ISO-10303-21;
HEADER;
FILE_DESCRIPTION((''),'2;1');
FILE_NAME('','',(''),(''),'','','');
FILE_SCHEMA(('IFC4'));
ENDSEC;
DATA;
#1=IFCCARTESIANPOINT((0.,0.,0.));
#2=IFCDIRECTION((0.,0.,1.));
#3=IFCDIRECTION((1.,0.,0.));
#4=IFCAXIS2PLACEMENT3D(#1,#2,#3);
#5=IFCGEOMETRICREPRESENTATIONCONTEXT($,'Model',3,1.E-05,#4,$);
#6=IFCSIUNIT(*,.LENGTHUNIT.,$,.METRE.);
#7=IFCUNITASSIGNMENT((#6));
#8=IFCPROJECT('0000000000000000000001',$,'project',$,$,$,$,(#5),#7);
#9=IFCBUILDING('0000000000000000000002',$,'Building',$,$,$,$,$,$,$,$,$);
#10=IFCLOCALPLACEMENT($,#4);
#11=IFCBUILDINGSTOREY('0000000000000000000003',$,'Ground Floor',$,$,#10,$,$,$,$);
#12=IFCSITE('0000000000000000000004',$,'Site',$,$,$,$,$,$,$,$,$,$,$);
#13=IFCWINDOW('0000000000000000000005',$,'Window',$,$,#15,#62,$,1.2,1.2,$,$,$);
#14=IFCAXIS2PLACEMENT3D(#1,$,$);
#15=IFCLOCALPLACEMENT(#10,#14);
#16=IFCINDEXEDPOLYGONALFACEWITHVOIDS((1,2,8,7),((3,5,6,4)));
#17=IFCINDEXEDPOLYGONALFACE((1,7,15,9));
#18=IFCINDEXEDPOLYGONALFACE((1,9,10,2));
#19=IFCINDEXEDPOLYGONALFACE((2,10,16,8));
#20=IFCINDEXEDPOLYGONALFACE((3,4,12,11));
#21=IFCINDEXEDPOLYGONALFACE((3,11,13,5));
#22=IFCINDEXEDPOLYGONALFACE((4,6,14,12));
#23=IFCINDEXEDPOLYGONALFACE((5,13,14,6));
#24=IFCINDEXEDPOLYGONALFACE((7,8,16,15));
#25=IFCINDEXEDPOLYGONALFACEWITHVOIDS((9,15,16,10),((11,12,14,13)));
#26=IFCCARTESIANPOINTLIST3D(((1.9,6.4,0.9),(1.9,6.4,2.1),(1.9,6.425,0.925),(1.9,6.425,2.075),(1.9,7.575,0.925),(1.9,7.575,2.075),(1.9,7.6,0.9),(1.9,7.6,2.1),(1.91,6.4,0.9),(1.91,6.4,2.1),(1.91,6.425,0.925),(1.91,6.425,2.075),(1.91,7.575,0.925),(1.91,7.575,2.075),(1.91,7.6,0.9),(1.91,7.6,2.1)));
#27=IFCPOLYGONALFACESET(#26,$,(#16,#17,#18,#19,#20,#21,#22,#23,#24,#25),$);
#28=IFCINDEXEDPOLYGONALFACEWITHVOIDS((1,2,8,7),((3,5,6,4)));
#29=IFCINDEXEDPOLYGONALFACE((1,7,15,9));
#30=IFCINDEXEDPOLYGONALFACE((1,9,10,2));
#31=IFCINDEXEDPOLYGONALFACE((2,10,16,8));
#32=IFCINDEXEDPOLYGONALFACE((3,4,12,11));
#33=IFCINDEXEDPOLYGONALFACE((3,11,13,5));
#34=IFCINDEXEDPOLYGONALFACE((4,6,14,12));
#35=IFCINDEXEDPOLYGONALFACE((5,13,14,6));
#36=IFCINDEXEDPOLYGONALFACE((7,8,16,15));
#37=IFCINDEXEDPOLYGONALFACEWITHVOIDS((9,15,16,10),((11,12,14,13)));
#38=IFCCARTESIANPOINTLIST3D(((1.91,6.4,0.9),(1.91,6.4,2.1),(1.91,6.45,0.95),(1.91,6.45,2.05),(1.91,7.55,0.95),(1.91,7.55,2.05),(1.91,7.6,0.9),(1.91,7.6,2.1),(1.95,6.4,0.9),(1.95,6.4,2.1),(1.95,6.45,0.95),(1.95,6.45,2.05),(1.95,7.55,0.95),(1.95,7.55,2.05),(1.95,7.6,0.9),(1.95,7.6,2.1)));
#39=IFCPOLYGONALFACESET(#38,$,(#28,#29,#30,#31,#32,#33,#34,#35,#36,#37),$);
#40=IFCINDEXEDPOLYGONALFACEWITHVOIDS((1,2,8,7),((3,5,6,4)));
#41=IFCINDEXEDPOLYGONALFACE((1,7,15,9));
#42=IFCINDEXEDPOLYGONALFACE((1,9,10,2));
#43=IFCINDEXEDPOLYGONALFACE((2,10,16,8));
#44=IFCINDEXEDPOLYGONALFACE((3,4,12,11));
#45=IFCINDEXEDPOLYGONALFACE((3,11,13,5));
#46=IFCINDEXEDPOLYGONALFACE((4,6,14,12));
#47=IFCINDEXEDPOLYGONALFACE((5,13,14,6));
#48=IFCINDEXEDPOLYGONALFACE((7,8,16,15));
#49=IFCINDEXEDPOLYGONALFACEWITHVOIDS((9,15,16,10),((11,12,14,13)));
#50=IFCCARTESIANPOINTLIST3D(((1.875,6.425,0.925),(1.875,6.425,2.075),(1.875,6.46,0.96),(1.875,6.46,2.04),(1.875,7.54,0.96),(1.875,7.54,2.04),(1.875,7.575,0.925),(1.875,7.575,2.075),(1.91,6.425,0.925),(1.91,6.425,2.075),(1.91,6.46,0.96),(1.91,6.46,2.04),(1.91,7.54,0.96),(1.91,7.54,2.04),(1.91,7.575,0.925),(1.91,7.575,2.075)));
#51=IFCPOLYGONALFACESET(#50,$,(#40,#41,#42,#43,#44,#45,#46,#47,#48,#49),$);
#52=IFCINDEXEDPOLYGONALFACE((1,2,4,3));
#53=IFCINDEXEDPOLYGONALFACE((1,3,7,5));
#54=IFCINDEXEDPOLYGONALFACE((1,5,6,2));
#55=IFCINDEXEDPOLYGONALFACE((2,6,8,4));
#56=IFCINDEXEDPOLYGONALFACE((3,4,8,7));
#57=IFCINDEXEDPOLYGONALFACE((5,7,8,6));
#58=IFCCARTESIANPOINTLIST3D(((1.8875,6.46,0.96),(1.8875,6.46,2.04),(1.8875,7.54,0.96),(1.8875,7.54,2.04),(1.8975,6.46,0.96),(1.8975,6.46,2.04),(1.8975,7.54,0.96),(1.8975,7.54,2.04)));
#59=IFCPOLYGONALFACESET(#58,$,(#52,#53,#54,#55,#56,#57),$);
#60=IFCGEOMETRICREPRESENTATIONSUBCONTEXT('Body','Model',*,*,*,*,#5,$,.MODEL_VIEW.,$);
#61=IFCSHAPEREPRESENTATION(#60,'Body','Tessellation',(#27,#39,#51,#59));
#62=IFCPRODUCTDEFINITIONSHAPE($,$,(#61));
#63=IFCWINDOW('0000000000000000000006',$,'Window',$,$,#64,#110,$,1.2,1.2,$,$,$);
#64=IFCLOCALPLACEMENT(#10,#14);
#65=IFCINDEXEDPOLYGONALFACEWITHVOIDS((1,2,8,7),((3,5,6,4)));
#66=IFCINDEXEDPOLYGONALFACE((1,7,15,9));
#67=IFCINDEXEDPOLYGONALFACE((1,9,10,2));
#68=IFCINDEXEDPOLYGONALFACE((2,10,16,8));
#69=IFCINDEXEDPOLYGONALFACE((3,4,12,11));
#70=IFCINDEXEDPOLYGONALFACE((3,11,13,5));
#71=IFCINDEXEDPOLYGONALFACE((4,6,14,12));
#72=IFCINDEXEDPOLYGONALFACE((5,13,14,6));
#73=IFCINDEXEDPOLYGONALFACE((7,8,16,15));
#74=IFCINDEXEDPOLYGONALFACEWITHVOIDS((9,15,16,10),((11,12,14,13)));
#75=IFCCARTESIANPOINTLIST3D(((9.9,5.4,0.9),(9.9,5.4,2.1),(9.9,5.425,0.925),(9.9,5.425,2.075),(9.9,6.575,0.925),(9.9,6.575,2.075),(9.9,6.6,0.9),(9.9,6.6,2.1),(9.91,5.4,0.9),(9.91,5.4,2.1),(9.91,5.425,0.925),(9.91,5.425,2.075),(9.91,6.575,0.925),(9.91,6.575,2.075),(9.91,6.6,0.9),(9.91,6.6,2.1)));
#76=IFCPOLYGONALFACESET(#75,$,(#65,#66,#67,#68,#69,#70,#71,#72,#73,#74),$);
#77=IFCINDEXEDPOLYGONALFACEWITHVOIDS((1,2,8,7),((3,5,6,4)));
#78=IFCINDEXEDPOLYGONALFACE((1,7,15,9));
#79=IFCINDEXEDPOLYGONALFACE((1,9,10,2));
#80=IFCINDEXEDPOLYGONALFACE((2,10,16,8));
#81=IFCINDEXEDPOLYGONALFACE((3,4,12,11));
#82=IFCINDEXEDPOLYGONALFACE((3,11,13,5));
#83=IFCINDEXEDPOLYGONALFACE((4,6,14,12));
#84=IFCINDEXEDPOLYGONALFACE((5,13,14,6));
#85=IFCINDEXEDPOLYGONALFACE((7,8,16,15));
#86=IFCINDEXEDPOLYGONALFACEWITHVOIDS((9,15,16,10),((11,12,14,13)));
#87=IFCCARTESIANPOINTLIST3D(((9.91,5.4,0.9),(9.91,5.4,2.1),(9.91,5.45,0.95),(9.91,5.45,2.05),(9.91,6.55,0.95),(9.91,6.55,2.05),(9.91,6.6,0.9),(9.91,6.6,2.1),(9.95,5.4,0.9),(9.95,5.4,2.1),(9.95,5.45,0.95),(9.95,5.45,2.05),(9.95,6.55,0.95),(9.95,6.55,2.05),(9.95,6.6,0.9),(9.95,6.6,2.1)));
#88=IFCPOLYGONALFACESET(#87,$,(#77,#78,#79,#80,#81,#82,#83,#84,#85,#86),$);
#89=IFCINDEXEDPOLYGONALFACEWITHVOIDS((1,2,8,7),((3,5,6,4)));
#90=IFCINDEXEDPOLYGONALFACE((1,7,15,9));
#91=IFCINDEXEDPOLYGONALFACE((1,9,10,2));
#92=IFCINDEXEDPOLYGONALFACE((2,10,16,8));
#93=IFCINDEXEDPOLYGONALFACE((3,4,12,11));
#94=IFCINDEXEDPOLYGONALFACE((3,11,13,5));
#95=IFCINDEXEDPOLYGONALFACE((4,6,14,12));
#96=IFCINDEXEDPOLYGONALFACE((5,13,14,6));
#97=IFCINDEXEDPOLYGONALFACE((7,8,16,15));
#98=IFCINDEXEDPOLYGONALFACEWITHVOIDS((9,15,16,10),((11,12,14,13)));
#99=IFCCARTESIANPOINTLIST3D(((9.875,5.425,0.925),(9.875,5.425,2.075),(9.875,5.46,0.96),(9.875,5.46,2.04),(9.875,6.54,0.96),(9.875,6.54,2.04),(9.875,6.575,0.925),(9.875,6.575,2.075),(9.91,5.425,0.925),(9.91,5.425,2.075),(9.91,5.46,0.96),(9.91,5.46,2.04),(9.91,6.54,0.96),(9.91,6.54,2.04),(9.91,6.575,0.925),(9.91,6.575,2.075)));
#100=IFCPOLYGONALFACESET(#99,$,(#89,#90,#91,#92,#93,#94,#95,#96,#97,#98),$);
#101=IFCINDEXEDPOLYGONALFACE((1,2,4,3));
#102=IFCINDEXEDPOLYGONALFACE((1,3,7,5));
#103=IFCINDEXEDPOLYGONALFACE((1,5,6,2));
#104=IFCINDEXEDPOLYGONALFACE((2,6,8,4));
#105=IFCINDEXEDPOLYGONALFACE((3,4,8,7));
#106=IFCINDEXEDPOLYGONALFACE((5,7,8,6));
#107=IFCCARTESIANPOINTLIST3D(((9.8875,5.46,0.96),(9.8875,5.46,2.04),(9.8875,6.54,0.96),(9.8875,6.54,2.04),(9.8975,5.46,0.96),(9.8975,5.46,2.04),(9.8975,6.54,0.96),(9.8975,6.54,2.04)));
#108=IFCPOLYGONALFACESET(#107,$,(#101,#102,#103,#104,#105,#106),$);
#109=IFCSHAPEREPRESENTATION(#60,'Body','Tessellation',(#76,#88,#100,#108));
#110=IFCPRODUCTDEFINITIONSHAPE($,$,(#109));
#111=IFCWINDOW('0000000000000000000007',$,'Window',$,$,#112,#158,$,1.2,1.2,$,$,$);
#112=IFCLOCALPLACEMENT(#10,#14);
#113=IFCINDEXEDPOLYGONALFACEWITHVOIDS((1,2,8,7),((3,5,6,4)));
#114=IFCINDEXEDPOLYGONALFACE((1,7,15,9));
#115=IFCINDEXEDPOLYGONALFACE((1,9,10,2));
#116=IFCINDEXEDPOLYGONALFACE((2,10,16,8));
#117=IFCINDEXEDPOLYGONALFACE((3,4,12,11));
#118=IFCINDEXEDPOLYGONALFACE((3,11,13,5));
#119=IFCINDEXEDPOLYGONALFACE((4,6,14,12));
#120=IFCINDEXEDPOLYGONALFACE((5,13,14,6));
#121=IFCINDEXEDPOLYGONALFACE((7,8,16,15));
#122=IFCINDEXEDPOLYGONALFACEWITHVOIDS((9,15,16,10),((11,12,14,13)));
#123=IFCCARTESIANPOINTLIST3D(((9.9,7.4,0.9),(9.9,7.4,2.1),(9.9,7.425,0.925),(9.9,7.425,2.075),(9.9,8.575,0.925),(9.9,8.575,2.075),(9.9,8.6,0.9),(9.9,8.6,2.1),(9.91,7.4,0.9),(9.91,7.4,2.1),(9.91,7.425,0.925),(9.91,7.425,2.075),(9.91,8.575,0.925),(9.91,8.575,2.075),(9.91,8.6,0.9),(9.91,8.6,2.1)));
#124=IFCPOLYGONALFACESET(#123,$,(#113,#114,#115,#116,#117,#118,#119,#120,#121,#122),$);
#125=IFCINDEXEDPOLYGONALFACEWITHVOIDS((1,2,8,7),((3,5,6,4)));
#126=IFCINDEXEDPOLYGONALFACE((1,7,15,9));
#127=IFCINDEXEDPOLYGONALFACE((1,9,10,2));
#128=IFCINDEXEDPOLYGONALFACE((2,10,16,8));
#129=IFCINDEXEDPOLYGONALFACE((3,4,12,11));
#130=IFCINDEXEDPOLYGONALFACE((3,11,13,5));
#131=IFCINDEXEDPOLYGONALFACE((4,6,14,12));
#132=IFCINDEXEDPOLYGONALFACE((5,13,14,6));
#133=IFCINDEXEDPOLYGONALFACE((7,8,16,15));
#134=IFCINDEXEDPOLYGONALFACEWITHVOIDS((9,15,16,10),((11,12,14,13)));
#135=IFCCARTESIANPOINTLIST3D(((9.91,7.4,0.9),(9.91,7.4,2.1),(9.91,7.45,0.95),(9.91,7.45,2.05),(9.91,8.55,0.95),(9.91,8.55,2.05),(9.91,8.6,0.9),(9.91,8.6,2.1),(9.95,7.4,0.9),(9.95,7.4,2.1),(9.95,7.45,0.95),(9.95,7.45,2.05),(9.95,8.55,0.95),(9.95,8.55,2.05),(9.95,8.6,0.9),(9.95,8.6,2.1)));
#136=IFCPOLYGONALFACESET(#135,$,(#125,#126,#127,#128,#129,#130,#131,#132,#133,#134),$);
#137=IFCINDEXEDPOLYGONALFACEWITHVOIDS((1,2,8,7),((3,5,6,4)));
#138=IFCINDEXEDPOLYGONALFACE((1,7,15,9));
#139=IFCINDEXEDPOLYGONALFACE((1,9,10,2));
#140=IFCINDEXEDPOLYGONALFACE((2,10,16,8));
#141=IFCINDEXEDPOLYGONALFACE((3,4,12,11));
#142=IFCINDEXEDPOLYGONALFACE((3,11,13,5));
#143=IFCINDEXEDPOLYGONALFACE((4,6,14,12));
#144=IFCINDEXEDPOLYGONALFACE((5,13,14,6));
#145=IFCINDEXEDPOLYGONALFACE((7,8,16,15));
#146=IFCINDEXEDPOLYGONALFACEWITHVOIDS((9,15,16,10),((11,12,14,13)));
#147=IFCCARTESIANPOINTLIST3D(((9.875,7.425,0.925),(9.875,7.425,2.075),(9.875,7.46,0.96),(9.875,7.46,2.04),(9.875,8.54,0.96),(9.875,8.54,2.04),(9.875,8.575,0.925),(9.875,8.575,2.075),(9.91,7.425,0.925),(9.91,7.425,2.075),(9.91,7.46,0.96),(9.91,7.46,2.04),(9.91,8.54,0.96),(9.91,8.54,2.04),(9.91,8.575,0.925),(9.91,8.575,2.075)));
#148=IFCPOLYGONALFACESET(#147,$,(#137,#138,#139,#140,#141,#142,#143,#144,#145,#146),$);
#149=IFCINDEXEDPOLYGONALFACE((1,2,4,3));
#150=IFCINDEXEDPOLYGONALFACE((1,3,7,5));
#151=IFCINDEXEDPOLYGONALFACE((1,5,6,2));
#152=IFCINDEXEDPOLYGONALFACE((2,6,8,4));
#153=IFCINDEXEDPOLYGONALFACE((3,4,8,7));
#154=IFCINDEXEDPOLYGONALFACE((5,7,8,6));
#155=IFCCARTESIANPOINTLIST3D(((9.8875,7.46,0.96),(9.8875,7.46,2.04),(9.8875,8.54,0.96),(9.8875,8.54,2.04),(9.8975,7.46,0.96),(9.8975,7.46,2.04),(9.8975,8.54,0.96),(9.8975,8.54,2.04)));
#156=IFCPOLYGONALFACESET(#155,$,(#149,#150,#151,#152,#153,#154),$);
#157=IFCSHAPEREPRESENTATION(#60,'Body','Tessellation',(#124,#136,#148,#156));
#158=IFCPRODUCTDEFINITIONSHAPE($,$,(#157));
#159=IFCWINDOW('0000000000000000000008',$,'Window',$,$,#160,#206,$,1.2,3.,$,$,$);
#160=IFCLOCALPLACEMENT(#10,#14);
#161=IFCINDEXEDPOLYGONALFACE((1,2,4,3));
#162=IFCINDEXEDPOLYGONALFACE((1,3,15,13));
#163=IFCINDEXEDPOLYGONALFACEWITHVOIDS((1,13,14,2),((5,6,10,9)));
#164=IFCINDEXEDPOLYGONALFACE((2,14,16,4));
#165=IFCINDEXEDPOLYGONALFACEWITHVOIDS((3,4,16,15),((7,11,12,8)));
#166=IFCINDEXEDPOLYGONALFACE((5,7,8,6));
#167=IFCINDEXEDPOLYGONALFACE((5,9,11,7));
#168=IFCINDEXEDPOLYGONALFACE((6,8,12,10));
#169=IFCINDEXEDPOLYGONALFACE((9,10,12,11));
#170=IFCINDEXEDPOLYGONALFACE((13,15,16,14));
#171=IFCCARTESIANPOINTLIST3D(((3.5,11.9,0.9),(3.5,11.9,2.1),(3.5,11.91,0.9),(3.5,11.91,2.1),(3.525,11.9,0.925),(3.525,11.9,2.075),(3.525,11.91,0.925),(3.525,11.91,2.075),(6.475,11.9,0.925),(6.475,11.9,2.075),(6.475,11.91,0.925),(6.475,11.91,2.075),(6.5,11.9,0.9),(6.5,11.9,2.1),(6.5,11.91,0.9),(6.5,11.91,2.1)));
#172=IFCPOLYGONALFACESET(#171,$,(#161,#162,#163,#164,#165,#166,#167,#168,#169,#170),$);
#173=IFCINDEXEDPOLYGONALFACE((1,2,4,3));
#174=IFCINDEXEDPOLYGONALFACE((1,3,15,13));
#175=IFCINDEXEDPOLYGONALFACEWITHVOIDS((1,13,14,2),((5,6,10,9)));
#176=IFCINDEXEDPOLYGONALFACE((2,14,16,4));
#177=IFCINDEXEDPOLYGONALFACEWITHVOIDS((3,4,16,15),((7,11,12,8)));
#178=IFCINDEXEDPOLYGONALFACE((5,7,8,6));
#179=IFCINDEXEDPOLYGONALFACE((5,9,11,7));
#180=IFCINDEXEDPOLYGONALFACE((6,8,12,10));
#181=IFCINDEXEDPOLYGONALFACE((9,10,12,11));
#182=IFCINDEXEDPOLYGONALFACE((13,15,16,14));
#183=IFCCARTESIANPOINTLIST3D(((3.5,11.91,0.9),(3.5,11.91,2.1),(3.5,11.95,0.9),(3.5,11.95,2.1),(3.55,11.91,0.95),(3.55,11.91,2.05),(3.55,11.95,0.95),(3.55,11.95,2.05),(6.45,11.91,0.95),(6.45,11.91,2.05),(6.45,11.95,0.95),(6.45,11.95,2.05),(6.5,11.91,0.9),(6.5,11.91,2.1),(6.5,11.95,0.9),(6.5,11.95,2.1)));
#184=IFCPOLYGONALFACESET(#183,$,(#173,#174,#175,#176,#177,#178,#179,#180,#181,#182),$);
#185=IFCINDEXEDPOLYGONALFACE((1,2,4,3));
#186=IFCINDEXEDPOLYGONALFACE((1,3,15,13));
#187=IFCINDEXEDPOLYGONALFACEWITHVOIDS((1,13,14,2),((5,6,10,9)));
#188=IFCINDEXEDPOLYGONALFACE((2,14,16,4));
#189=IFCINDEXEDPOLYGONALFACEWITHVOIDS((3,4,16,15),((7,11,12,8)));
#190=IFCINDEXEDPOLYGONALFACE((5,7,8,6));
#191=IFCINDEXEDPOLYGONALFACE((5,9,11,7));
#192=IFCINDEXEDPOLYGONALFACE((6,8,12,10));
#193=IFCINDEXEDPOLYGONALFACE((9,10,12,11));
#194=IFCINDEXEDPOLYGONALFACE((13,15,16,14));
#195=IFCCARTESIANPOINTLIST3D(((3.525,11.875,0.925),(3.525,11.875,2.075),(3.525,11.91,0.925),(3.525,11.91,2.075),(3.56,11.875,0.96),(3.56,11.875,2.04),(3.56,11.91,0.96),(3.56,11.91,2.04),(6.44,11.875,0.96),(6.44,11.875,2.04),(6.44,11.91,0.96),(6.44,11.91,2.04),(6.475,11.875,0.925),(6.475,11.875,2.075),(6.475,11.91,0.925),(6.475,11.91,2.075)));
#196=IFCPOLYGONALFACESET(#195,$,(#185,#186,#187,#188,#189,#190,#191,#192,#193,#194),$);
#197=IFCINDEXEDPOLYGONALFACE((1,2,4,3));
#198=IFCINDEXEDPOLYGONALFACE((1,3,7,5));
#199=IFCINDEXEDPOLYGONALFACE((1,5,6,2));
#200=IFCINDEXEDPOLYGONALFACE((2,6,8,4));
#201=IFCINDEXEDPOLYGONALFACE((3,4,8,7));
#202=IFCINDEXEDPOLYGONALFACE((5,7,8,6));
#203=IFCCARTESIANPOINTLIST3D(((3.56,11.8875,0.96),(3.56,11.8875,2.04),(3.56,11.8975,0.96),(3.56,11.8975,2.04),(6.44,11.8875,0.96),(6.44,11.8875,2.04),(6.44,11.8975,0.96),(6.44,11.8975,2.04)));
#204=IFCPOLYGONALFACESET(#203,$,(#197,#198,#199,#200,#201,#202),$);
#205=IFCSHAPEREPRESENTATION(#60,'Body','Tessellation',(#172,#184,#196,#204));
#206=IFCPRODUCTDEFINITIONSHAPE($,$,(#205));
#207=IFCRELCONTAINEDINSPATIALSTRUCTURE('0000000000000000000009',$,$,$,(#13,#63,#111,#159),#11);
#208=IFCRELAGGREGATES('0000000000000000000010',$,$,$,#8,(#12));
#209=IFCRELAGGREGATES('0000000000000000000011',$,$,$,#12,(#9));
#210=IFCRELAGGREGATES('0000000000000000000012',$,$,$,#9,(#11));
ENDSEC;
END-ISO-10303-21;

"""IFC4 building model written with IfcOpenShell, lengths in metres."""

from ifc_helpers import new_model, si_unit, frame, origin_with_axes, place, context, subcontext, project, spatial, line, indexed_curve, outline, extrude, element, save


model = new_model("IFC4")

# Units and contexts
model_context = context("Model", 3, precision=1e-05, world=origin_with_axes())
body_context = subcontext(model_context, "Body", "Model", "MODEL_VIEW")
ifc_project = project(units=[si_unit("LENGTHUNIT", "METRE")], contexts=[model_context])

# Site, building, storey
site = spatial("IfcSite", under=ifc_project, Name="Site")
building = spatial("IfcBuilding", under=site, Name="Building")
storey_placement = place(None, origin_with_axes())
storey = spatial("IfcBuildingStorey", under=building, at=storey_placement, Name="Ground Floor")

# Windows
for number, where, z_axis, x_axis, name in (
    (1, (2.0, 6.4, 0.9), (0.0, 0.0, 1.0), (0.0, 1.0, 0.0), "Window"),
    (2, (10.0, 5.4, 0.9), (0.0, 0.0, 1.0), (0.0, 1.0, 0.0), "Window"),
    (3, (10.0, 7.4, 0.9), (0.0, 0.0, 1.0), (0.0, 1.0, 0.0), "Window"),
):
    element("IfcWindow", number, at=place(storey_placement, frame(where, z_axis=z_axis, x_axis=x_axis)), inside=storey, Name=name, OverallHeight=1.2, OverallWidth=1.2, context=body_context, shape_type="SweptSolid", body=[
        extrude(outline(indexed_curve([(0.0, 0.0), (1.2, 0.0), (1.2, 1.2), (0.0, 1.2)], segments=[line(1, 2, 3, 4, 1)]), holes=[indexed_curve([(0.025, 0.025), (1.175, 0.025), (1.175, 1.175), (0.025, 1.175)], segments=[line(1, 2, 3, 4, 1)])]), frame((0.0, 0.09, 0.0), z_axis=(0.0, -1.0, 0.0), x_axis=(1.0, 0.0, 0.0)), (0.0, 0.0, -1.0), 0.01),
        extrude(outline(indexed_curve([(0.0, 0.0), (1.2, 0.0), (1.2, 1.2), (0.0, 1.2)], segments=[line(1, 2, 3, 4, 1)]), holes=[indexed_curve([(0.05, 0.05), (1.15, 0.05), (1.15, 1.15), (0.05, 1.15)], segments=[line(1, 2, 3, 4, 1)])]), frame((0.0, 0.05, 0.0), z_axis=(0.0, -1.0, 0.0), x_axis=(1.0, 0.0, 0.0)), (0.0, 0.0, -1.0), 0.04),
        extrude(outline(indexed_curve([(0.0, 0.0), (1.15, 0.0), (1.15, 1.15), (0.0, 1.15)], segments=[line(1, 2, 3, 4, 1)]), holes=[indexed_curve([(0.035, 0.035), (1.115, 0.035), (1.115, 1.115), (0.035, 1.115)], segments=[line(1, 2, 3, 4, 1)])]), frame((0.025, 0.09, 0.025), z_axis=(0.0, -1.0, 0.0), x_axis=(1.0, 0.0, 0.0)), (0.0, 0.0, -1.0), 0.035),
        extrude(outline(indexed_curve([(0.035, 0.035), (1.115, 0.035), (1.115, 1.115), (0.035, 1.115)], segments=[line(1, 2, 3, 4, 1)])), frame((0.025, 0.1025, 0.025), z_axis=(0.0, -1.0, 0.0), x_axis=(1.0, 0.0, 0.0)), (0.0, 0.0, -1.0), 0.01),
    ])
window_1_placement = place(storey_placement, frame((6.5, 12.0, 0.9), z_axis=(0.0, 0.0, 1.0), x_axis=(-1.0, 0.0, 0.0)))
element("IfcWindow", 4, at=window_1_placement, inside=storey, Name="Window", OverallHeight=1.2, OverallWidth=3.0, context=body_context, shape_type="SweptSolid", body=[
    extrude(outline(indexed_curve([(0.0, 0.0), (3.0, 0.0), (3.0, 1.2), (0.0, 1.2)], segments=[line(1, 2, 3, 4, 1)]), holes=[indexed_curve([(0.025, 0.025), (2.975, 0.025), (2.975, 1.175), (0.025, 1.175)], segments=[line(1, 2, 3, 4, 1)])]), frame((0.0, 0.09, 0.0), z_axis=(0.0, -1.0, 0.0), x_axis=(1.0, 0.0, 0.0)), (0.0, 0.0, -1.0), 0.01),
    extrude(outline(indexed_curve([(0.0, 0.0), (3.0, 0.0), (3.0, 1.2), (0.0, 1.2)], segments=[line(1, 2, 3, 4, 1)]), holes=[indexed_curve([(0.05, 0.05), (2.95, 0.05), (2.95, 1.15), (0.05, 1.15)], segments=[line(1, 2, 3, 4, 1)])]), frame((0.0, 0.05, 0.0), z_axis=(0.0, -1.0, 0.0), x_axis=(1.0, 0.0, 0.0)), (0.0, 0.0, -1.0), 0.04),
    extrude(outline(indexed_curve([(0.0, 0.0), (2.95, 0.0), (2.95, 1.15), (0.0, 1.15)], segments=[line(1, 2, 3, 4, 1)]), holes=[indexed_curve([(0.035, 0.035), (2.915, 0.035), (2.915, 1.115), (0.035, 1.115)], segments=[line(1, 2, 3, 4, 1)])]), frame((0.025, 0.09, 0.025), z_axis=(0.0, -1.0, 0.0), x_axis=(1.0, 0.0, 0.0)), (0.0, 0.0, -1.0), 0.035),
    extrude(outline(indexed_curve([(0.035, 0.035), (2.915, 0.035), (2.915, 1.115), (0.035, 1.115)], segments=[line(1, 2, 3, 4, 1)])), frame((0.025, 0.1025, 0.025), z_axis=(0.0, -1.0, 0.0), x_axis=(1.0, 0.0, 0.0)), (0.0, 0.0, -1.0), 0.01),
])

save(model, "model.ifc")
